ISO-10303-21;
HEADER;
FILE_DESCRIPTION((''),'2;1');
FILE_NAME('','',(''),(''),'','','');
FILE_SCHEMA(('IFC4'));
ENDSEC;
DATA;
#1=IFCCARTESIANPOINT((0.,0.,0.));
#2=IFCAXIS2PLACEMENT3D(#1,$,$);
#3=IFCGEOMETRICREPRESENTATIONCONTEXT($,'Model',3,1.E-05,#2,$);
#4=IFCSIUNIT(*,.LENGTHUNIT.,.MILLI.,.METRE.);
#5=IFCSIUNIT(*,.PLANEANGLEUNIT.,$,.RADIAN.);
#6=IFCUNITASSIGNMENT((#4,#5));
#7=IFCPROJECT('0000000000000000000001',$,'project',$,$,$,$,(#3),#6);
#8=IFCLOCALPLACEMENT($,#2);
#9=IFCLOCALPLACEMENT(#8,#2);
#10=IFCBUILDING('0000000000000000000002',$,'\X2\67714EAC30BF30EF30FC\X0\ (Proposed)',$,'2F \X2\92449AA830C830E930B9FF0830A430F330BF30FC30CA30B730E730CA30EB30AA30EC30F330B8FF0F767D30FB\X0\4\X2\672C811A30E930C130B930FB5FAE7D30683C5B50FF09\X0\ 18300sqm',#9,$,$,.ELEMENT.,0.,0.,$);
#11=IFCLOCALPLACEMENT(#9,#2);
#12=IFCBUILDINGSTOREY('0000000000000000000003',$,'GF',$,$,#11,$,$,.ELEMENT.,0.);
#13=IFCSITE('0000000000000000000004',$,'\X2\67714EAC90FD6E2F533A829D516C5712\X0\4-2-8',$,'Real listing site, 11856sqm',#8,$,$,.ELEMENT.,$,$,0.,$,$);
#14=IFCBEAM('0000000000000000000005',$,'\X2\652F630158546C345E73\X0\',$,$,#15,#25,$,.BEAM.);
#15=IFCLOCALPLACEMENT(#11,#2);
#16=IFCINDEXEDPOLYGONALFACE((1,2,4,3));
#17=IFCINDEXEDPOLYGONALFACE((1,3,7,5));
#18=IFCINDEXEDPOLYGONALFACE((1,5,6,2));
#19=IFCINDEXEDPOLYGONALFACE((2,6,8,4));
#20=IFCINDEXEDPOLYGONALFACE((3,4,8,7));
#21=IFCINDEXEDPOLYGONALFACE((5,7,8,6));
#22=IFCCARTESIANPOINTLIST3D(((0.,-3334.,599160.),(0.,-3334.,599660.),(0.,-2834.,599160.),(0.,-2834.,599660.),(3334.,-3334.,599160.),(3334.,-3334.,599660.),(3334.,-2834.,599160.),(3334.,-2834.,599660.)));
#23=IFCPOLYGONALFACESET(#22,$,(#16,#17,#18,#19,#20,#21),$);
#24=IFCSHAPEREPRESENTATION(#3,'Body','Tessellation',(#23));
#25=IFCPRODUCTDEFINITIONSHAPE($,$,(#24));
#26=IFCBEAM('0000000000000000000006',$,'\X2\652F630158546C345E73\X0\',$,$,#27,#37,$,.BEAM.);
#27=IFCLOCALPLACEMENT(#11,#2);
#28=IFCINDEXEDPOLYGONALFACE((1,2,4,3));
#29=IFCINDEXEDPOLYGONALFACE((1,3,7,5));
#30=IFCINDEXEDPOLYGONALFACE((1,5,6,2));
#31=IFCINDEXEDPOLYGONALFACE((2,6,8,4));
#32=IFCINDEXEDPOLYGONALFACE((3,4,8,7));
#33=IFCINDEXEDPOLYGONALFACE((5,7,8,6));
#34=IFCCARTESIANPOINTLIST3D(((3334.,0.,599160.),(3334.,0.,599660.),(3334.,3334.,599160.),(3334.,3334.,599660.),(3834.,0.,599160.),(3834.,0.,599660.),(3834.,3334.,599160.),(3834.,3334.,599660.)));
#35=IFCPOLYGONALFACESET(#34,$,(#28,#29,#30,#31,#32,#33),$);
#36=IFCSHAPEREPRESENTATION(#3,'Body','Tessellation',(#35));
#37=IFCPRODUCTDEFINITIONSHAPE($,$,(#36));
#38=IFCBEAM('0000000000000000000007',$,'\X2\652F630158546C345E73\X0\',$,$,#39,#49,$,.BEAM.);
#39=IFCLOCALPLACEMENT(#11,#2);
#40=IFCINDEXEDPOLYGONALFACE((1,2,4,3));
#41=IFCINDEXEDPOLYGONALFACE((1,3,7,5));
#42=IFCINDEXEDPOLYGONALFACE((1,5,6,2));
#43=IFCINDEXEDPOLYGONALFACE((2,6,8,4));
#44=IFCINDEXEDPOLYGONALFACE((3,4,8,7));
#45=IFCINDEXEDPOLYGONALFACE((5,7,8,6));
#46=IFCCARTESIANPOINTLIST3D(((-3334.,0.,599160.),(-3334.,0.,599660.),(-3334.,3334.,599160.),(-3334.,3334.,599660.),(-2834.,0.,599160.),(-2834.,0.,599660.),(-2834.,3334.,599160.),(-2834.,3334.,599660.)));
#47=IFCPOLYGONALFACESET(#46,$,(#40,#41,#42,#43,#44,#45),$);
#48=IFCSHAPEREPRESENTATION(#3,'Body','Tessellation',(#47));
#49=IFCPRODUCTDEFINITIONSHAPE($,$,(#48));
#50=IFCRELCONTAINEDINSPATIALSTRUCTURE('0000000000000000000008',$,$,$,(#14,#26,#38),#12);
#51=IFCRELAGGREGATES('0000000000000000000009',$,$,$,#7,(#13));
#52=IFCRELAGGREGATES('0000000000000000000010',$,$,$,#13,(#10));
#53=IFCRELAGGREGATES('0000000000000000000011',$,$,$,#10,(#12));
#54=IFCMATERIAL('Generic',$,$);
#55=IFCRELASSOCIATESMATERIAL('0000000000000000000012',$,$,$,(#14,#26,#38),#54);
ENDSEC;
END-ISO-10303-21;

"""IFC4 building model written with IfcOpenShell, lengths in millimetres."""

from ifc_helpers import new_model, si_unit, frame, frame_2d, origin, place, context, project, spatial, rectangle, extrude, material, element, save


model = new_model("IFC4")

# Units and contexts
model_context = context("Model", 3, precision=1e-05, world=origin())
ifc_project = project(units=[si_unit("LENGTHUNIT", "METRE", prefix="MILLI"), si_unit("PLANEANGLEUNIT", "RADIAN")], contexts=[model_context])

# Site, building, storey
site_placement = place(None, origin())
site = spatial("IfcSite", under=ifc_project, at=site_placement, Name="東京都港区芝公園4-2-8", ObjectType="Real listing site, 11856sqm", CompositionType="ELEMENT", RefElevation=0.0)
building_placement = place(site_placement, origin())
building = spatial("IfcBuilding", under=site, at=building_placement, Name="東京タワー (Proposed)", ObjectType="2F 鉄骨トラス（インターナショナルオレンジ／白・4本脚ラチス・微細格子） 18300sqm", CompositionType="ELEMENT", ElevationOfRefHeight=0.0, ElevationOfTerrain=0.0)
storey_placement = place(building_placement, origin())
storey = spatial("IfcBuildingStorey", under=building, at=storey_placement, Name="GF", CompositionType="ELEMENT", Elevation=0.0)

# Beams
ifc_material = material(Name="Generic")
beam_1_placement = place(storey_placement, frame((0.0, -1667.0, 299580.0)))
element("IfcBeam", 1, at=beam_1_placement, inside=storey, material=ifc_material, Name="支持塔水平", PredefinedType="BEAM", context=model_context, shape_type="SweptSolid", body=[
    extrude(rectangle(XDim=3334.0, YDim=500.0, at=frame_2d((1667.0, 250.0))), frame((0.0, -1667.0, 299580.0)), (0.0, 0.0, 1.0), 500.0),
])
beam_2_placement = place(storey_placement, frame((1667.0, 0.0, 299580.0)))
element("IfcBeam", 2, at=beam_2_placement, inside=storey, material=ifc_material, Name="支持塔水平", PredefinedType="BEAM", context=model_context, shape_type="SweptSolid", body=[
    extrude(rectangle(XDim=500.0, YDim=3334.0, at=frame_2d((250.0, 1667.0))), frame((1667.0, 0.0, 299580.0)), (0.0, 0.0, 1.0), 500.0),
])
beam_3_placement = place(storey_placement, frame((-1667.0, 0.0, 299580.0)))
element("IfcBeam", 3, at=beam_3_placement, inside=storey, material=ifc_material, Name="支持塔水平", PredefinedType="BEAM", context=model_context, shape_type="SweptSolid", body=[
    extrude(rectangle(XDim=500.0, YDim=3334.0, at=frame_2d((250.0, 1667.0))), frame((-1667.0, 0.0, 299580.0)), (0.0, 0.0, 1.0), 500.0),
])

save(model, "model.ifc")
